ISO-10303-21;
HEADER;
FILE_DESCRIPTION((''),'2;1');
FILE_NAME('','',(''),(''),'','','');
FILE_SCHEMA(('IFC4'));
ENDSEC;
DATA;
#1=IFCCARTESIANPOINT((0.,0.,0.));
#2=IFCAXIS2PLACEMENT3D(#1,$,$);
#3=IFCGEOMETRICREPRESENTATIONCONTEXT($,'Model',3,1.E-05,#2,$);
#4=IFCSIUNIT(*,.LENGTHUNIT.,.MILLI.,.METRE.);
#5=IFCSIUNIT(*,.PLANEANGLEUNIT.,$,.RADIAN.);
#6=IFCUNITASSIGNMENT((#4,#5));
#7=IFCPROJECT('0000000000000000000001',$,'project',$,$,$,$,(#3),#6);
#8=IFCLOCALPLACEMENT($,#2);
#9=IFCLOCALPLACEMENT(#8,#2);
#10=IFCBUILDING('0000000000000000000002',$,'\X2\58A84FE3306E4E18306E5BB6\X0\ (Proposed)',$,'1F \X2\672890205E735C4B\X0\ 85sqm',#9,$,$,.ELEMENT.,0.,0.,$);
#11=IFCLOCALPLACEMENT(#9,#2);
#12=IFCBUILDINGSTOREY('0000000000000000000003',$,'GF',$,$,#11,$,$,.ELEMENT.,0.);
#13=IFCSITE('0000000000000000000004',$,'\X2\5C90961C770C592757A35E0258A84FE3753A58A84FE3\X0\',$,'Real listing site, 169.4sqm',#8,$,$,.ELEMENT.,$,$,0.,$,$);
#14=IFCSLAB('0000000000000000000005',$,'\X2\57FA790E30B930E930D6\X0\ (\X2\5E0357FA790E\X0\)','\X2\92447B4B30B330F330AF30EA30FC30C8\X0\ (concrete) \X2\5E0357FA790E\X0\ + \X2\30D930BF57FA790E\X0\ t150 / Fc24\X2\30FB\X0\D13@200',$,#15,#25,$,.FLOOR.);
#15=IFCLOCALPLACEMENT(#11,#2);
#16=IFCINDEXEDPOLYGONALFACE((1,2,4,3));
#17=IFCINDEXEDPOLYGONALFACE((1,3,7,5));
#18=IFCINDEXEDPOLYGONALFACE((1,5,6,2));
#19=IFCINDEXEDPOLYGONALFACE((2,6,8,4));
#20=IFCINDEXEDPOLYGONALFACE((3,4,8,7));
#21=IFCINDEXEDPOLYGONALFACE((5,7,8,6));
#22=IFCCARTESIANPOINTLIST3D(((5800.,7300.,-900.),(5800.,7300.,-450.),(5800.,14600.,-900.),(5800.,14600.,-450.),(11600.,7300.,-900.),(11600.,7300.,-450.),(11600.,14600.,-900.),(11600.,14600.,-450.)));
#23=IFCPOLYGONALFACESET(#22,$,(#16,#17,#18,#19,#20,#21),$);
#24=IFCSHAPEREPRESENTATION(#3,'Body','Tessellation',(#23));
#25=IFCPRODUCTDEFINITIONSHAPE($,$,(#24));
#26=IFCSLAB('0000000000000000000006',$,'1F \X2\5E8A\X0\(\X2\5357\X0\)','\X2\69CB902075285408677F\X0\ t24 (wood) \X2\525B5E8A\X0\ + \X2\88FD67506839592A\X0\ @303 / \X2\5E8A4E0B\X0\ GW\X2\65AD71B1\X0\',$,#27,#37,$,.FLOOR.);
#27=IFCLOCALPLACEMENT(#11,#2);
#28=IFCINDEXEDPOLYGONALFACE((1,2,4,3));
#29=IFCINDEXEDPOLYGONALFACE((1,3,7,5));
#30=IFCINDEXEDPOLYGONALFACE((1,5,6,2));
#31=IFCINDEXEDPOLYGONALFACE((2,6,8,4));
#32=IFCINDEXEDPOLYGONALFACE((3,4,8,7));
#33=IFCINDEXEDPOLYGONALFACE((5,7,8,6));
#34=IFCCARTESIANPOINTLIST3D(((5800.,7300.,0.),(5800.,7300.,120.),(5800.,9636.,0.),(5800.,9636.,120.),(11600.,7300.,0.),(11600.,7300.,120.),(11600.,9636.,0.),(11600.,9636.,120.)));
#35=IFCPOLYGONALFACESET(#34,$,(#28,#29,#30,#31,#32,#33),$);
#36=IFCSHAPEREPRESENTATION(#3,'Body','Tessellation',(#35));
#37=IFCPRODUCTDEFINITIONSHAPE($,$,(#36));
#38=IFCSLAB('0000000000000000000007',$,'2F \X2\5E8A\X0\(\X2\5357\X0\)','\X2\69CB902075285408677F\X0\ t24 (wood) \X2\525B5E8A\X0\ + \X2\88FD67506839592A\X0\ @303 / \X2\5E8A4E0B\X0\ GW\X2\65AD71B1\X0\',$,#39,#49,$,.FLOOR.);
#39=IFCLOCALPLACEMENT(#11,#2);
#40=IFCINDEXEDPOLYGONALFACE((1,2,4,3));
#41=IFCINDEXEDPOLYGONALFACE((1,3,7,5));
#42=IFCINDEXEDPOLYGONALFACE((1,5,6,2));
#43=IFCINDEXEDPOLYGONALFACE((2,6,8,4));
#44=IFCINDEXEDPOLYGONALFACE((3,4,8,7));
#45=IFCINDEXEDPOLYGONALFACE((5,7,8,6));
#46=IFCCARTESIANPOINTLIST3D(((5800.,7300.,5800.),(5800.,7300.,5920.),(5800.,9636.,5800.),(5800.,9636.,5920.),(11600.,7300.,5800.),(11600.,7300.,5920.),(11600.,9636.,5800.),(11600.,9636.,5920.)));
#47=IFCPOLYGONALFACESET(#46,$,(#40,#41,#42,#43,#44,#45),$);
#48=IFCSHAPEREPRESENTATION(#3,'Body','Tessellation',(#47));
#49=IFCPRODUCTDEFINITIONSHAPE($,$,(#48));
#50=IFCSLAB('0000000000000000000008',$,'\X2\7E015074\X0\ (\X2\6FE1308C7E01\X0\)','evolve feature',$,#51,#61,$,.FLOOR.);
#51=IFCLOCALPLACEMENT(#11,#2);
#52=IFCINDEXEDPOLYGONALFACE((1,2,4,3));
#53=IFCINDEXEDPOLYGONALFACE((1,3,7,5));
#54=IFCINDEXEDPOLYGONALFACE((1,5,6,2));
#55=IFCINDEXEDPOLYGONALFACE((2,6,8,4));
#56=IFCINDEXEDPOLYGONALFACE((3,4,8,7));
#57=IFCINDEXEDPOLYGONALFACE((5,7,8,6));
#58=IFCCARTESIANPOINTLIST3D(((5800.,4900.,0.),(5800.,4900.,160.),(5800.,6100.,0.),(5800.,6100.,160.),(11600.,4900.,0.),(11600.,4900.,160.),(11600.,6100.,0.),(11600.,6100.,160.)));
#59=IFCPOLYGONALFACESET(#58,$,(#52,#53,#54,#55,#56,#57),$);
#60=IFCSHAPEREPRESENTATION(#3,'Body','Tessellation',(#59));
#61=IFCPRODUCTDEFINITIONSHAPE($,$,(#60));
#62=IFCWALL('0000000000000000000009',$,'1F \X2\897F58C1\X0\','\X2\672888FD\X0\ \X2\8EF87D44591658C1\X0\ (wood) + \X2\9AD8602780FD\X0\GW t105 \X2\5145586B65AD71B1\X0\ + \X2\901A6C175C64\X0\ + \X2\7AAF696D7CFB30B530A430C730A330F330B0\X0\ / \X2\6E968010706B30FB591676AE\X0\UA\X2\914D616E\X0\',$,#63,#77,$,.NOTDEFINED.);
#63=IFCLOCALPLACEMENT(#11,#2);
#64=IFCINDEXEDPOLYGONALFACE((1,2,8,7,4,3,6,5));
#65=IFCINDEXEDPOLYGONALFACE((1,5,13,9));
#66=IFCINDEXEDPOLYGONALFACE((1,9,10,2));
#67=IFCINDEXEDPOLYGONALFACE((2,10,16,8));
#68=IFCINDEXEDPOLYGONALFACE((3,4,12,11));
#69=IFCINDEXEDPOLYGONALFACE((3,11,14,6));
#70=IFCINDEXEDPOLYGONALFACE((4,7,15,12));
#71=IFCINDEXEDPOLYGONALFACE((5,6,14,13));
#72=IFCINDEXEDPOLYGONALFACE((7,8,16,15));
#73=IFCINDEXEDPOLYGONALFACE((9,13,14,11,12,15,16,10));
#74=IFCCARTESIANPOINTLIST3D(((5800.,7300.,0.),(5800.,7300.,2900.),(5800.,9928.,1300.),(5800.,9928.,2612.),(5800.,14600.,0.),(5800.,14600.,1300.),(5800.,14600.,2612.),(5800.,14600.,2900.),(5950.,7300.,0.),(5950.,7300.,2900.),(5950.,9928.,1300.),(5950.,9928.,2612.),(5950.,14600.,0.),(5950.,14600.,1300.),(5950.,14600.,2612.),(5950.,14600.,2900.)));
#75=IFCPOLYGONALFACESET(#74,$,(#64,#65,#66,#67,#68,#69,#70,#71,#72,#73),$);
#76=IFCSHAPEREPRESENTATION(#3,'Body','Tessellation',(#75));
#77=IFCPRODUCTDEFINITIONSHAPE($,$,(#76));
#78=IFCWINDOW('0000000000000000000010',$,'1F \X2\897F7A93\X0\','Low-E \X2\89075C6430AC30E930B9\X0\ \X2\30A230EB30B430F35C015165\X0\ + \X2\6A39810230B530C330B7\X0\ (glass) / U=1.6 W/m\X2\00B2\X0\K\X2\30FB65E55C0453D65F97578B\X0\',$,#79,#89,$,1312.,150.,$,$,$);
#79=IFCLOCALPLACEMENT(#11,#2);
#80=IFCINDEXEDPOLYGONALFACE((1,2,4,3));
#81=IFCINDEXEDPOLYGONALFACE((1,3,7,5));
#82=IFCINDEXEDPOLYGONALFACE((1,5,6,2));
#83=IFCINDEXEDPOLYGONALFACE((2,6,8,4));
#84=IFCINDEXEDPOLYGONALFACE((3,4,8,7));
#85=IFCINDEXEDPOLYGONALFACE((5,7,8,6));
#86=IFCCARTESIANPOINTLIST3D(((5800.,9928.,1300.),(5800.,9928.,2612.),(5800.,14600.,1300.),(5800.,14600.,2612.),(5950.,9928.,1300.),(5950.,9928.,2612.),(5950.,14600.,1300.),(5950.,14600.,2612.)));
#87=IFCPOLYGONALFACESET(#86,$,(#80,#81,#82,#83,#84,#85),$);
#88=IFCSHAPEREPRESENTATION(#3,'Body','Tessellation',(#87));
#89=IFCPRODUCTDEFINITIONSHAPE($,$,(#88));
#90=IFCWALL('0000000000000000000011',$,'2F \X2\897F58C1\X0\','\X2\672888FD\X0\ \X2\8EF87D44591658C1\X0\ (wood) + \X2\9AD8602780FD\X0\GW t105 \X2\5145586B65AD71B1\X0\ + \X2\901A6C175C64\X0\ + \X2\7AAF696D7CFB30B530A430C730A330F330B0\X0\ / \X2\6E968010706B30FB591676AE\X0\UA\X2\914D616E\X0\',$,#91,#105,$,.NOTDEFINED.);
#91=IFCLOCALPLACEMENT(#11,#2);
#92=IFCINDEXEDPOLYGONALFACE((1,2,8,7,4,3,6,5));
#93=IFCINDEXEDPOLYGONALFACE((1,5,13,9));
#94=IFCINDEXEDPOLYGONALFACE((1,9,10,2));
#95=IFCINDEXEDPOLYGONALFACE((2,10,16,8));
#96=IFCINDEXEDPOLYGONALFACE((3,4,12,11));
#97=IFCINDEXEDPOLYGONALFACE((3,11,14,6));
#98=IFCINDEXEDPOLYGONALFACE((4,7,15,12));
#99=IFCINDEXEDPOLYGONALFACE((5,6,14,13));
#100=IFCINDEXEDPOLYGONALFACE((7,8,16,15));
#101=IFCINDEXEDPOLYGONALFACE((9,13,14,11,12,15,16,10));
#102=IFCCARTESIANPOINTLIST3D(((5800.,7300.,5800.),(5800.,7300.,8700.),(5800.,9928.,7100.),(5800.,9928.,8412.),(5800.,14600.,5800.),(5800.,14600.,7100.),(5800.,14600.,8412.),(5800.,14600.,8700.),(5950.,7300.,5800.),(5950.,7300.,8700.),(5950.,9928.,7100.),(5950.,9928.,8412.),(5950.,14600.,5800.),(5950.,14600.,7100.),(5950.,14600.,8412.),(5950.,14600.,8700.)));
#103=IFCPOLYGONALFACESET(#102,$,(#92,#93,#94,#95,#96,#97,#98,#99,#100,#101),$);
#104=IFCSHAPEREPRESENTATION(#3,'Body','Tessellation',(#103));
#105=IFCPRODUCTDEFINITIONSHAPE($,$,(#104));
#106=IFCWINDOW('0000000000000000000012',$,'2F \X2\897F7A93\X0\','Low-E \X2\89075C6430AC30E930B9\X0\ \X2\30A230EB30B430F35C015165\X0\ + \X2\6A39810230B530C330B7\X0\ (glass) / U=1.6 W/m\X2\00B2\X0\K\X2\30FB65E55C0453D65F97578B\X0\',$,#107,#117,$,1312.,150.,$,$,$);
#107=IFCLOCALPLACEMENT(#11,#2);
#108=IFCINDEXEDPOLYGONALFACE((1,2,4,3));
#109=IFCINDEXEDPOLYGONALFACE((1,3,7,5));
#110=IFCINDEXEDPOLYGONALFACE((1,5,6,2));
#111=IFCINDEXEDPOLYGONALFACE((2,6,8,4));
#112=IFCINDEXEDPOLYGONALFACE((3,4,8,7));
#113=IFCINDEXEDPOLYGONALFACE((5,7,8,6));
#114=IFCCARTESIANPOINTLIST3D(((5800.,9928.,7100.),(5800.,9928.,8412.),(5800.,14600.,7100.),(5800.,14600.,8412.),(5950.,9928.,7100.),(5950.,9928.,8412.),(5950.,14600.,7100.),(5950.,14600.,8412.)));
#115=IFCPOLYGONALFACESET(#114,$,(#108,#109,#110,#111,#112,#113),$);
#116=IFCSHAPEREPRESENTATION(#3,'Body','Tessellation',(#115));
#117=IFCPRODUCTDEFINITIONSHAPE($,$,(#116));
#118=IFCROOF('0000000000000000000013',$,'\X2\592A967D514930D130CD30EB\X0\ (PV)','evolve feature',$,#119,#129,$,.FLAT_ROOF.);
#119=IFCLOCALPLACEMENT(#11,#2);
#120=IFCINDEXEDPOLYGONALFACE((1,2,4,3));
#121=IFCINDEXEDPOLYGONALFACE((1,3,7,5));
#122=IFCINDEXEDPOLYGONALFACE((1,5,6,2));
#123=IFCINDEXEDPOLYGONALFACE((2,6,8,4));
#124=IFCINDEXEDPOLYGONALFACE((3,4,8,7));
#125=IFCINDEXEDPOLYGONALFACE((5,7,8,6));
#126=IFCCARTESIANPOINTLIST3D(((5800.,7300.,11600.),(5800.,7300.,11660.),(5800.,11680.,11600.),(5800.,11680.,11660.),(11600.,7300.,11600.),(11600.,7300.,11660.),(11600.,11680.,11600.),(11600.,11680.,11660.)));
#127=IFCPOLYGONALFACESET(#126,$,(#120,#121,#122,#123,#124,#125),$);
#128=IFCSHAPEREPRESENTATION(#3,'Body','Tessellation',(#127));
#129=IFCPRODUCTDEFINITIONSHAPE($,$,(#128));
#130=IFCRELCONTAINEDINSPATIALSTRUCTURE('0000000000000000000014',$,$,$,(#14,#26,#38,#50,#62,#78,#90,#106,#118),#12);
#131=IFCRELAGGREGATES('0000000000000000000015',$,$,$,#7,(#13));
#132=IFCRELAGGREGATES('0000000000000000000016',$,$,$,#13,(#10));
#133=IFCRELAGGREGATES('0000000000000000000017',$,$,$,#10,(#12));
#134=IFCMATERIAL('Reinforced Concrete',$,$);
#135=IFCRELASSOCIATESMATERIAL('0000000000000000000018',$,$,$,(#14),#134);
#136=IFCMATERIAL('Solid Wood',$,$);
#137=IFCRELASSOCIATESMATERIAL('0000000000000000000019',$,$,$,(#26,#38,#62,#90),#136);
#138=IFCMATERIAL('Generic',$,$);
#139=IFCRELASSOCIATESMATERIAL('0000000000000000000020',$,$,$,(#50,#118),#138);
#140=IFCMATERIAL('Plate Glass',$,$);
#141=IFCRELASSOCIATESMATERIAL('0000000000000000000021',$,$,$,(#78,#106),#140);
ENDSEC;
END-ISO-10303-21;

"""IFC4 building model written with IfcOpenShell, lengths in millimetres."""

from ifc_helpers import new_model, si_unit, frame, frame_2d, origin, place, context, project, spatial, rectangle, extrude, material, element, fill, save


model = new_model("IFC4")

# Units and contexts
model_context = context("Model", 3, precision=1e-05, world=origin())
ifc_project = project(units=[si_unit("LENGTHUNIT", "METRE", prefix="MILLI"), si_unit("PLANEANGLEUNIT", "RADIAN")], contexts=[model_context])

# Site, building, storey
site_placement = place(None, origin())
site = spatial("IfcSite", under=ifc_project, at=site_placement, Name="岐阜県大垣市墨俣町墨俣", ObjectType="Real listing site, 169.4sqm", CompositionType="ELEMENT", RefElevation=0.0)
building_placement = place(site_placement, origin())
building = spatial("IfcBuilding", under=site, at=building_placement, Name="墨俣の丘の家 (Proposed)", ObjectType="1F 木造平屋 85sqm", CompositionType="ELEMENT", ElevationOfRefHeight=0.0, ElevationOfTerrain=0.0)
storey_placement = place(building_placement, origin())
storey = spatial("IfcBuildingStorey", under=building, at=storey_placement, Name="GF", CompositionType="ELEMENT", Elevation=0.0)

# Slabs
ifc_material_1 = material(Name="Reinforced Concrete")
slab_1_placement = place(storey_placement, frame((2900.0, 3650.0, -450.0)))
element("IfcSlab", 1, at=slab_1_placement, inside=storey, material=ifc_material_1, Name="基礎スラブ (布基礎)", Description="鉄筋コンクリート (concrete) 布基礎 + ベタ基礎 t150 / Fc24・D13@200", PredefinedType="FLOOR", context=model_context, shape_type="SweptSolid", body=[
    extrude(rectangle(XDim=5800.0, YDim=7300.0, at=frame_2d((2900.0, 3650.0))), frame((2900.0, 3650.0, -450.0)), (0.0, 0.0, 1.0), 450.0),
])
ifc_material_2 = material(Name="Solid Wood")
slab_2_placement = place(storey_placement, frame((2900.0, 3650.0, 0.0)))
element("IfcSlab", 2, at=slab_2_placement, inside=storey, material=ifc_material_2, Name="1F 床(南)", Description="構造用合板 t24 (wood) 剛床 + 製材根太 @303 / 床下 GW断熱", PredefinedType="FLOOR", context=model_context, shape_type="SweptSolid", body=[
    extrude(rectangle(XDim=5800.0, YDim=2336.0, at=frame_2d((2900.0, 1168.0))), frame((2900.0, 3650.0, 0.0)), (0.0, 0.0, 1.0), 120.0),
])
slab_3_placement = place(storey_placement, frame((2900.0, 3650.0, 2900.0)))
element("IfcSlab", 3, at=slab_3_placement, inside=storey, material=ifc_material_2, Name="2F 床(南)", Description="構造用合板 t24 (wood) 剛床 + 製材根太 @303 / 床下 GW断熱", PredefinedType="FLOOR", context=model_context, shape_type="SweptSolid", body=[
    extrude(rectangle(XDim=5800.0, YDim=2336.0, at=frame_2d((2900.0, 1168.0))), frame((2900.0, 3650.0, 2900.0)), (0.0, 0.0, 1.0), 120.0),
])
ifc_material_3 = material(Name="Generic")
slab_4_placement = place(storey_placement, frame((2900.0, 2450.0, 0.0)))
element("IfcSlab", 4, at=slab_4_placement, inside=storey, material=ifc_material_3, Name="縁側 (濡れ縁)", Description="evolve feature", PredefinedType="FLOOR", context=model_context, shape_type="SweptSolid", body=[
    extrude(rectangle(XDim=5800.0, YDim=1200.0, at=frame_2d((2900.0, 600.0))), frame((2900.0, 2450.0, 0.0)), (0.0, 0.0, 1.0), 160.0),
])

# Shared definitions
ifc_material_4 = material(Name="Plate Glass")

# Walls, openings, windows
wall_1_placement = place(storey_placement, frame((2900.0, 3650.0, 0.0)))
wall_1 = element("IfcWall", 5, at=wall_1_placement, inside=storey, material=ifc_material_2, Name="1F 西壁", Description="木製 軸組外壁 (wood) + 高性能GW t105 充填断熱 + 通気層 + 窯業系サイディング / 準耐火・外皮UA配慮", PredefinedType="NOTDEFINED", context=model_context, shape_type="SweptSolid", body=[
    extrude(rectangle(XDim=150.0, YDim=7300.0, at=frame_2d((75.0, 3650.0))), frame((2900.0, 3650.0, 0.0)), (0.0, 0.0, 1.0), 2900.0),
])
opening_1_placement = place(storey_placement, frame((2900.0, 4964.0, 650.0)))
opening_1 = element("IfcOpeningElement", 6, at=opening_1_placement, cuts=wall_1, PredefinedType="NOTDEFINED", context=model_context, shape_type="SweptSolid", body=[
    extrude(rectangle(XDim=150.0, YDim=4672.0, at=frame_2d((75.0, 2336.0))), frame((2900.0, 4964.0, 650.0)), (0.0, 0.0, 1.0), 1312.0),
])
window_1_placement = place(storey_placement, frame((2900.0, 4964.0, 650.0)))
window_1 = element("IfcWindow", 7, at=window_1_placement, inside=storey, material=ifc_material_4, Name="1F 西窓", Description="Low-E 複層ガラス アルゴン封入 + 樹脂サッシ (glass) / U=1.6 W/m²K・日射取得型", OverallHeight=1312.0, OverallWidth=150.0, context=model_context, shape_type="SweptSolid", body=[
    extrude(rectangle(XDim=150.0, YDim=4672.0, at=frame_2d((75.0, 2336.0))), frame((2900.0, 4964.0, 650.0)), (0.0, 0.0, 1.0), 1312.0),
])
fill(opening_1, window_1)
wall_2_placement = place(storey_placement, frame((2900.0, 3650.0, 2900.0)))
wall_2 = element("IfcWall", 8, at=wall_2_placement, inside=storey, material=ifc_material_2, Name="2F 西壁", Description="木製 軸組外壁 (wood) + 高性能GW t105 充填断熱 + 通気層 + 窯業系サイディング / 準耐火・外皮UA配慮", PredefinedType="NOTDEFINED", context=model_context, shape_type="SweptSolid", body=[
    extrude(rectangle(XDim=150.0, YDim=7300.0, at=frame_2d((75.0, 3650.0))), frame((2900.0, 3650.0, 2900.0)), (0.0, 0.0, 1.0), 2900.0),
])
opening_2_placement = place(storey_placement, frame((2900.0, 4964.0, 3550.0)))
opening_2 = element("IfcOpeningElement", 9, at=opening_2_placement, cuts=wall_2, PredefinedType="NOTDEFINED", context=model_context, shape_type="SweptSolid", body=[
    extrude(rectangle(XDim=150.0, YDim=4672.0, at=frame_2d((75.0, 2336.0))), frame((2900.0, 4964.0, 3550.0)), (0.0, 0.0, 1.0), 1312.0),
])
window_2_placement = place(storey_placement, frame((2900.0, 4964.0, 3550.0)))
window_2 = element("IfcWindow", 10, at=window_2_placement, inside=storey, material=ifc_material_4, Name="2F 西窓", Description="Low-E 複層ガラス アルゴン封入 + 樹脂サッシ (glass) / U=1.6 W/m²K・日射取得型", OverallHeight=1312.0, OverallWidth=150.0, context=model_context, shape_type="SweptSolid", body=[
    extrude(rectangle(XDim=150.0, YDim=4672.0, at=frame_2d((75.0, 2336.0))), frame((2900.0, 4964.0, 3550.0)), (0.0, 0.0, 1.0), 1312.0),
])
fill(opening_2, window_2)

# Roof
roof_1_placement = place(storey_placement, frame((2900.0, 3650.0, 5800.0)))
element("IfcRoof", 11, at=roof_1_placement, inside=storey, material=ifc_material_3, Name="太陽光パネル (PV)", Description="evolve feature", PredefinedType="FLAT_ROOF", context=model_context, shape_type="SweptSolid", body=[
    extrude(rectangle(XDim=5800.0, YDim=4380.0, at=frame_2d((2900.0, 2190.0))), frame((2900.0, 3650.0, 5800.0)), (0.0, 0.0, 1.0), 60.0),
])

save(model, "model.ifc")
